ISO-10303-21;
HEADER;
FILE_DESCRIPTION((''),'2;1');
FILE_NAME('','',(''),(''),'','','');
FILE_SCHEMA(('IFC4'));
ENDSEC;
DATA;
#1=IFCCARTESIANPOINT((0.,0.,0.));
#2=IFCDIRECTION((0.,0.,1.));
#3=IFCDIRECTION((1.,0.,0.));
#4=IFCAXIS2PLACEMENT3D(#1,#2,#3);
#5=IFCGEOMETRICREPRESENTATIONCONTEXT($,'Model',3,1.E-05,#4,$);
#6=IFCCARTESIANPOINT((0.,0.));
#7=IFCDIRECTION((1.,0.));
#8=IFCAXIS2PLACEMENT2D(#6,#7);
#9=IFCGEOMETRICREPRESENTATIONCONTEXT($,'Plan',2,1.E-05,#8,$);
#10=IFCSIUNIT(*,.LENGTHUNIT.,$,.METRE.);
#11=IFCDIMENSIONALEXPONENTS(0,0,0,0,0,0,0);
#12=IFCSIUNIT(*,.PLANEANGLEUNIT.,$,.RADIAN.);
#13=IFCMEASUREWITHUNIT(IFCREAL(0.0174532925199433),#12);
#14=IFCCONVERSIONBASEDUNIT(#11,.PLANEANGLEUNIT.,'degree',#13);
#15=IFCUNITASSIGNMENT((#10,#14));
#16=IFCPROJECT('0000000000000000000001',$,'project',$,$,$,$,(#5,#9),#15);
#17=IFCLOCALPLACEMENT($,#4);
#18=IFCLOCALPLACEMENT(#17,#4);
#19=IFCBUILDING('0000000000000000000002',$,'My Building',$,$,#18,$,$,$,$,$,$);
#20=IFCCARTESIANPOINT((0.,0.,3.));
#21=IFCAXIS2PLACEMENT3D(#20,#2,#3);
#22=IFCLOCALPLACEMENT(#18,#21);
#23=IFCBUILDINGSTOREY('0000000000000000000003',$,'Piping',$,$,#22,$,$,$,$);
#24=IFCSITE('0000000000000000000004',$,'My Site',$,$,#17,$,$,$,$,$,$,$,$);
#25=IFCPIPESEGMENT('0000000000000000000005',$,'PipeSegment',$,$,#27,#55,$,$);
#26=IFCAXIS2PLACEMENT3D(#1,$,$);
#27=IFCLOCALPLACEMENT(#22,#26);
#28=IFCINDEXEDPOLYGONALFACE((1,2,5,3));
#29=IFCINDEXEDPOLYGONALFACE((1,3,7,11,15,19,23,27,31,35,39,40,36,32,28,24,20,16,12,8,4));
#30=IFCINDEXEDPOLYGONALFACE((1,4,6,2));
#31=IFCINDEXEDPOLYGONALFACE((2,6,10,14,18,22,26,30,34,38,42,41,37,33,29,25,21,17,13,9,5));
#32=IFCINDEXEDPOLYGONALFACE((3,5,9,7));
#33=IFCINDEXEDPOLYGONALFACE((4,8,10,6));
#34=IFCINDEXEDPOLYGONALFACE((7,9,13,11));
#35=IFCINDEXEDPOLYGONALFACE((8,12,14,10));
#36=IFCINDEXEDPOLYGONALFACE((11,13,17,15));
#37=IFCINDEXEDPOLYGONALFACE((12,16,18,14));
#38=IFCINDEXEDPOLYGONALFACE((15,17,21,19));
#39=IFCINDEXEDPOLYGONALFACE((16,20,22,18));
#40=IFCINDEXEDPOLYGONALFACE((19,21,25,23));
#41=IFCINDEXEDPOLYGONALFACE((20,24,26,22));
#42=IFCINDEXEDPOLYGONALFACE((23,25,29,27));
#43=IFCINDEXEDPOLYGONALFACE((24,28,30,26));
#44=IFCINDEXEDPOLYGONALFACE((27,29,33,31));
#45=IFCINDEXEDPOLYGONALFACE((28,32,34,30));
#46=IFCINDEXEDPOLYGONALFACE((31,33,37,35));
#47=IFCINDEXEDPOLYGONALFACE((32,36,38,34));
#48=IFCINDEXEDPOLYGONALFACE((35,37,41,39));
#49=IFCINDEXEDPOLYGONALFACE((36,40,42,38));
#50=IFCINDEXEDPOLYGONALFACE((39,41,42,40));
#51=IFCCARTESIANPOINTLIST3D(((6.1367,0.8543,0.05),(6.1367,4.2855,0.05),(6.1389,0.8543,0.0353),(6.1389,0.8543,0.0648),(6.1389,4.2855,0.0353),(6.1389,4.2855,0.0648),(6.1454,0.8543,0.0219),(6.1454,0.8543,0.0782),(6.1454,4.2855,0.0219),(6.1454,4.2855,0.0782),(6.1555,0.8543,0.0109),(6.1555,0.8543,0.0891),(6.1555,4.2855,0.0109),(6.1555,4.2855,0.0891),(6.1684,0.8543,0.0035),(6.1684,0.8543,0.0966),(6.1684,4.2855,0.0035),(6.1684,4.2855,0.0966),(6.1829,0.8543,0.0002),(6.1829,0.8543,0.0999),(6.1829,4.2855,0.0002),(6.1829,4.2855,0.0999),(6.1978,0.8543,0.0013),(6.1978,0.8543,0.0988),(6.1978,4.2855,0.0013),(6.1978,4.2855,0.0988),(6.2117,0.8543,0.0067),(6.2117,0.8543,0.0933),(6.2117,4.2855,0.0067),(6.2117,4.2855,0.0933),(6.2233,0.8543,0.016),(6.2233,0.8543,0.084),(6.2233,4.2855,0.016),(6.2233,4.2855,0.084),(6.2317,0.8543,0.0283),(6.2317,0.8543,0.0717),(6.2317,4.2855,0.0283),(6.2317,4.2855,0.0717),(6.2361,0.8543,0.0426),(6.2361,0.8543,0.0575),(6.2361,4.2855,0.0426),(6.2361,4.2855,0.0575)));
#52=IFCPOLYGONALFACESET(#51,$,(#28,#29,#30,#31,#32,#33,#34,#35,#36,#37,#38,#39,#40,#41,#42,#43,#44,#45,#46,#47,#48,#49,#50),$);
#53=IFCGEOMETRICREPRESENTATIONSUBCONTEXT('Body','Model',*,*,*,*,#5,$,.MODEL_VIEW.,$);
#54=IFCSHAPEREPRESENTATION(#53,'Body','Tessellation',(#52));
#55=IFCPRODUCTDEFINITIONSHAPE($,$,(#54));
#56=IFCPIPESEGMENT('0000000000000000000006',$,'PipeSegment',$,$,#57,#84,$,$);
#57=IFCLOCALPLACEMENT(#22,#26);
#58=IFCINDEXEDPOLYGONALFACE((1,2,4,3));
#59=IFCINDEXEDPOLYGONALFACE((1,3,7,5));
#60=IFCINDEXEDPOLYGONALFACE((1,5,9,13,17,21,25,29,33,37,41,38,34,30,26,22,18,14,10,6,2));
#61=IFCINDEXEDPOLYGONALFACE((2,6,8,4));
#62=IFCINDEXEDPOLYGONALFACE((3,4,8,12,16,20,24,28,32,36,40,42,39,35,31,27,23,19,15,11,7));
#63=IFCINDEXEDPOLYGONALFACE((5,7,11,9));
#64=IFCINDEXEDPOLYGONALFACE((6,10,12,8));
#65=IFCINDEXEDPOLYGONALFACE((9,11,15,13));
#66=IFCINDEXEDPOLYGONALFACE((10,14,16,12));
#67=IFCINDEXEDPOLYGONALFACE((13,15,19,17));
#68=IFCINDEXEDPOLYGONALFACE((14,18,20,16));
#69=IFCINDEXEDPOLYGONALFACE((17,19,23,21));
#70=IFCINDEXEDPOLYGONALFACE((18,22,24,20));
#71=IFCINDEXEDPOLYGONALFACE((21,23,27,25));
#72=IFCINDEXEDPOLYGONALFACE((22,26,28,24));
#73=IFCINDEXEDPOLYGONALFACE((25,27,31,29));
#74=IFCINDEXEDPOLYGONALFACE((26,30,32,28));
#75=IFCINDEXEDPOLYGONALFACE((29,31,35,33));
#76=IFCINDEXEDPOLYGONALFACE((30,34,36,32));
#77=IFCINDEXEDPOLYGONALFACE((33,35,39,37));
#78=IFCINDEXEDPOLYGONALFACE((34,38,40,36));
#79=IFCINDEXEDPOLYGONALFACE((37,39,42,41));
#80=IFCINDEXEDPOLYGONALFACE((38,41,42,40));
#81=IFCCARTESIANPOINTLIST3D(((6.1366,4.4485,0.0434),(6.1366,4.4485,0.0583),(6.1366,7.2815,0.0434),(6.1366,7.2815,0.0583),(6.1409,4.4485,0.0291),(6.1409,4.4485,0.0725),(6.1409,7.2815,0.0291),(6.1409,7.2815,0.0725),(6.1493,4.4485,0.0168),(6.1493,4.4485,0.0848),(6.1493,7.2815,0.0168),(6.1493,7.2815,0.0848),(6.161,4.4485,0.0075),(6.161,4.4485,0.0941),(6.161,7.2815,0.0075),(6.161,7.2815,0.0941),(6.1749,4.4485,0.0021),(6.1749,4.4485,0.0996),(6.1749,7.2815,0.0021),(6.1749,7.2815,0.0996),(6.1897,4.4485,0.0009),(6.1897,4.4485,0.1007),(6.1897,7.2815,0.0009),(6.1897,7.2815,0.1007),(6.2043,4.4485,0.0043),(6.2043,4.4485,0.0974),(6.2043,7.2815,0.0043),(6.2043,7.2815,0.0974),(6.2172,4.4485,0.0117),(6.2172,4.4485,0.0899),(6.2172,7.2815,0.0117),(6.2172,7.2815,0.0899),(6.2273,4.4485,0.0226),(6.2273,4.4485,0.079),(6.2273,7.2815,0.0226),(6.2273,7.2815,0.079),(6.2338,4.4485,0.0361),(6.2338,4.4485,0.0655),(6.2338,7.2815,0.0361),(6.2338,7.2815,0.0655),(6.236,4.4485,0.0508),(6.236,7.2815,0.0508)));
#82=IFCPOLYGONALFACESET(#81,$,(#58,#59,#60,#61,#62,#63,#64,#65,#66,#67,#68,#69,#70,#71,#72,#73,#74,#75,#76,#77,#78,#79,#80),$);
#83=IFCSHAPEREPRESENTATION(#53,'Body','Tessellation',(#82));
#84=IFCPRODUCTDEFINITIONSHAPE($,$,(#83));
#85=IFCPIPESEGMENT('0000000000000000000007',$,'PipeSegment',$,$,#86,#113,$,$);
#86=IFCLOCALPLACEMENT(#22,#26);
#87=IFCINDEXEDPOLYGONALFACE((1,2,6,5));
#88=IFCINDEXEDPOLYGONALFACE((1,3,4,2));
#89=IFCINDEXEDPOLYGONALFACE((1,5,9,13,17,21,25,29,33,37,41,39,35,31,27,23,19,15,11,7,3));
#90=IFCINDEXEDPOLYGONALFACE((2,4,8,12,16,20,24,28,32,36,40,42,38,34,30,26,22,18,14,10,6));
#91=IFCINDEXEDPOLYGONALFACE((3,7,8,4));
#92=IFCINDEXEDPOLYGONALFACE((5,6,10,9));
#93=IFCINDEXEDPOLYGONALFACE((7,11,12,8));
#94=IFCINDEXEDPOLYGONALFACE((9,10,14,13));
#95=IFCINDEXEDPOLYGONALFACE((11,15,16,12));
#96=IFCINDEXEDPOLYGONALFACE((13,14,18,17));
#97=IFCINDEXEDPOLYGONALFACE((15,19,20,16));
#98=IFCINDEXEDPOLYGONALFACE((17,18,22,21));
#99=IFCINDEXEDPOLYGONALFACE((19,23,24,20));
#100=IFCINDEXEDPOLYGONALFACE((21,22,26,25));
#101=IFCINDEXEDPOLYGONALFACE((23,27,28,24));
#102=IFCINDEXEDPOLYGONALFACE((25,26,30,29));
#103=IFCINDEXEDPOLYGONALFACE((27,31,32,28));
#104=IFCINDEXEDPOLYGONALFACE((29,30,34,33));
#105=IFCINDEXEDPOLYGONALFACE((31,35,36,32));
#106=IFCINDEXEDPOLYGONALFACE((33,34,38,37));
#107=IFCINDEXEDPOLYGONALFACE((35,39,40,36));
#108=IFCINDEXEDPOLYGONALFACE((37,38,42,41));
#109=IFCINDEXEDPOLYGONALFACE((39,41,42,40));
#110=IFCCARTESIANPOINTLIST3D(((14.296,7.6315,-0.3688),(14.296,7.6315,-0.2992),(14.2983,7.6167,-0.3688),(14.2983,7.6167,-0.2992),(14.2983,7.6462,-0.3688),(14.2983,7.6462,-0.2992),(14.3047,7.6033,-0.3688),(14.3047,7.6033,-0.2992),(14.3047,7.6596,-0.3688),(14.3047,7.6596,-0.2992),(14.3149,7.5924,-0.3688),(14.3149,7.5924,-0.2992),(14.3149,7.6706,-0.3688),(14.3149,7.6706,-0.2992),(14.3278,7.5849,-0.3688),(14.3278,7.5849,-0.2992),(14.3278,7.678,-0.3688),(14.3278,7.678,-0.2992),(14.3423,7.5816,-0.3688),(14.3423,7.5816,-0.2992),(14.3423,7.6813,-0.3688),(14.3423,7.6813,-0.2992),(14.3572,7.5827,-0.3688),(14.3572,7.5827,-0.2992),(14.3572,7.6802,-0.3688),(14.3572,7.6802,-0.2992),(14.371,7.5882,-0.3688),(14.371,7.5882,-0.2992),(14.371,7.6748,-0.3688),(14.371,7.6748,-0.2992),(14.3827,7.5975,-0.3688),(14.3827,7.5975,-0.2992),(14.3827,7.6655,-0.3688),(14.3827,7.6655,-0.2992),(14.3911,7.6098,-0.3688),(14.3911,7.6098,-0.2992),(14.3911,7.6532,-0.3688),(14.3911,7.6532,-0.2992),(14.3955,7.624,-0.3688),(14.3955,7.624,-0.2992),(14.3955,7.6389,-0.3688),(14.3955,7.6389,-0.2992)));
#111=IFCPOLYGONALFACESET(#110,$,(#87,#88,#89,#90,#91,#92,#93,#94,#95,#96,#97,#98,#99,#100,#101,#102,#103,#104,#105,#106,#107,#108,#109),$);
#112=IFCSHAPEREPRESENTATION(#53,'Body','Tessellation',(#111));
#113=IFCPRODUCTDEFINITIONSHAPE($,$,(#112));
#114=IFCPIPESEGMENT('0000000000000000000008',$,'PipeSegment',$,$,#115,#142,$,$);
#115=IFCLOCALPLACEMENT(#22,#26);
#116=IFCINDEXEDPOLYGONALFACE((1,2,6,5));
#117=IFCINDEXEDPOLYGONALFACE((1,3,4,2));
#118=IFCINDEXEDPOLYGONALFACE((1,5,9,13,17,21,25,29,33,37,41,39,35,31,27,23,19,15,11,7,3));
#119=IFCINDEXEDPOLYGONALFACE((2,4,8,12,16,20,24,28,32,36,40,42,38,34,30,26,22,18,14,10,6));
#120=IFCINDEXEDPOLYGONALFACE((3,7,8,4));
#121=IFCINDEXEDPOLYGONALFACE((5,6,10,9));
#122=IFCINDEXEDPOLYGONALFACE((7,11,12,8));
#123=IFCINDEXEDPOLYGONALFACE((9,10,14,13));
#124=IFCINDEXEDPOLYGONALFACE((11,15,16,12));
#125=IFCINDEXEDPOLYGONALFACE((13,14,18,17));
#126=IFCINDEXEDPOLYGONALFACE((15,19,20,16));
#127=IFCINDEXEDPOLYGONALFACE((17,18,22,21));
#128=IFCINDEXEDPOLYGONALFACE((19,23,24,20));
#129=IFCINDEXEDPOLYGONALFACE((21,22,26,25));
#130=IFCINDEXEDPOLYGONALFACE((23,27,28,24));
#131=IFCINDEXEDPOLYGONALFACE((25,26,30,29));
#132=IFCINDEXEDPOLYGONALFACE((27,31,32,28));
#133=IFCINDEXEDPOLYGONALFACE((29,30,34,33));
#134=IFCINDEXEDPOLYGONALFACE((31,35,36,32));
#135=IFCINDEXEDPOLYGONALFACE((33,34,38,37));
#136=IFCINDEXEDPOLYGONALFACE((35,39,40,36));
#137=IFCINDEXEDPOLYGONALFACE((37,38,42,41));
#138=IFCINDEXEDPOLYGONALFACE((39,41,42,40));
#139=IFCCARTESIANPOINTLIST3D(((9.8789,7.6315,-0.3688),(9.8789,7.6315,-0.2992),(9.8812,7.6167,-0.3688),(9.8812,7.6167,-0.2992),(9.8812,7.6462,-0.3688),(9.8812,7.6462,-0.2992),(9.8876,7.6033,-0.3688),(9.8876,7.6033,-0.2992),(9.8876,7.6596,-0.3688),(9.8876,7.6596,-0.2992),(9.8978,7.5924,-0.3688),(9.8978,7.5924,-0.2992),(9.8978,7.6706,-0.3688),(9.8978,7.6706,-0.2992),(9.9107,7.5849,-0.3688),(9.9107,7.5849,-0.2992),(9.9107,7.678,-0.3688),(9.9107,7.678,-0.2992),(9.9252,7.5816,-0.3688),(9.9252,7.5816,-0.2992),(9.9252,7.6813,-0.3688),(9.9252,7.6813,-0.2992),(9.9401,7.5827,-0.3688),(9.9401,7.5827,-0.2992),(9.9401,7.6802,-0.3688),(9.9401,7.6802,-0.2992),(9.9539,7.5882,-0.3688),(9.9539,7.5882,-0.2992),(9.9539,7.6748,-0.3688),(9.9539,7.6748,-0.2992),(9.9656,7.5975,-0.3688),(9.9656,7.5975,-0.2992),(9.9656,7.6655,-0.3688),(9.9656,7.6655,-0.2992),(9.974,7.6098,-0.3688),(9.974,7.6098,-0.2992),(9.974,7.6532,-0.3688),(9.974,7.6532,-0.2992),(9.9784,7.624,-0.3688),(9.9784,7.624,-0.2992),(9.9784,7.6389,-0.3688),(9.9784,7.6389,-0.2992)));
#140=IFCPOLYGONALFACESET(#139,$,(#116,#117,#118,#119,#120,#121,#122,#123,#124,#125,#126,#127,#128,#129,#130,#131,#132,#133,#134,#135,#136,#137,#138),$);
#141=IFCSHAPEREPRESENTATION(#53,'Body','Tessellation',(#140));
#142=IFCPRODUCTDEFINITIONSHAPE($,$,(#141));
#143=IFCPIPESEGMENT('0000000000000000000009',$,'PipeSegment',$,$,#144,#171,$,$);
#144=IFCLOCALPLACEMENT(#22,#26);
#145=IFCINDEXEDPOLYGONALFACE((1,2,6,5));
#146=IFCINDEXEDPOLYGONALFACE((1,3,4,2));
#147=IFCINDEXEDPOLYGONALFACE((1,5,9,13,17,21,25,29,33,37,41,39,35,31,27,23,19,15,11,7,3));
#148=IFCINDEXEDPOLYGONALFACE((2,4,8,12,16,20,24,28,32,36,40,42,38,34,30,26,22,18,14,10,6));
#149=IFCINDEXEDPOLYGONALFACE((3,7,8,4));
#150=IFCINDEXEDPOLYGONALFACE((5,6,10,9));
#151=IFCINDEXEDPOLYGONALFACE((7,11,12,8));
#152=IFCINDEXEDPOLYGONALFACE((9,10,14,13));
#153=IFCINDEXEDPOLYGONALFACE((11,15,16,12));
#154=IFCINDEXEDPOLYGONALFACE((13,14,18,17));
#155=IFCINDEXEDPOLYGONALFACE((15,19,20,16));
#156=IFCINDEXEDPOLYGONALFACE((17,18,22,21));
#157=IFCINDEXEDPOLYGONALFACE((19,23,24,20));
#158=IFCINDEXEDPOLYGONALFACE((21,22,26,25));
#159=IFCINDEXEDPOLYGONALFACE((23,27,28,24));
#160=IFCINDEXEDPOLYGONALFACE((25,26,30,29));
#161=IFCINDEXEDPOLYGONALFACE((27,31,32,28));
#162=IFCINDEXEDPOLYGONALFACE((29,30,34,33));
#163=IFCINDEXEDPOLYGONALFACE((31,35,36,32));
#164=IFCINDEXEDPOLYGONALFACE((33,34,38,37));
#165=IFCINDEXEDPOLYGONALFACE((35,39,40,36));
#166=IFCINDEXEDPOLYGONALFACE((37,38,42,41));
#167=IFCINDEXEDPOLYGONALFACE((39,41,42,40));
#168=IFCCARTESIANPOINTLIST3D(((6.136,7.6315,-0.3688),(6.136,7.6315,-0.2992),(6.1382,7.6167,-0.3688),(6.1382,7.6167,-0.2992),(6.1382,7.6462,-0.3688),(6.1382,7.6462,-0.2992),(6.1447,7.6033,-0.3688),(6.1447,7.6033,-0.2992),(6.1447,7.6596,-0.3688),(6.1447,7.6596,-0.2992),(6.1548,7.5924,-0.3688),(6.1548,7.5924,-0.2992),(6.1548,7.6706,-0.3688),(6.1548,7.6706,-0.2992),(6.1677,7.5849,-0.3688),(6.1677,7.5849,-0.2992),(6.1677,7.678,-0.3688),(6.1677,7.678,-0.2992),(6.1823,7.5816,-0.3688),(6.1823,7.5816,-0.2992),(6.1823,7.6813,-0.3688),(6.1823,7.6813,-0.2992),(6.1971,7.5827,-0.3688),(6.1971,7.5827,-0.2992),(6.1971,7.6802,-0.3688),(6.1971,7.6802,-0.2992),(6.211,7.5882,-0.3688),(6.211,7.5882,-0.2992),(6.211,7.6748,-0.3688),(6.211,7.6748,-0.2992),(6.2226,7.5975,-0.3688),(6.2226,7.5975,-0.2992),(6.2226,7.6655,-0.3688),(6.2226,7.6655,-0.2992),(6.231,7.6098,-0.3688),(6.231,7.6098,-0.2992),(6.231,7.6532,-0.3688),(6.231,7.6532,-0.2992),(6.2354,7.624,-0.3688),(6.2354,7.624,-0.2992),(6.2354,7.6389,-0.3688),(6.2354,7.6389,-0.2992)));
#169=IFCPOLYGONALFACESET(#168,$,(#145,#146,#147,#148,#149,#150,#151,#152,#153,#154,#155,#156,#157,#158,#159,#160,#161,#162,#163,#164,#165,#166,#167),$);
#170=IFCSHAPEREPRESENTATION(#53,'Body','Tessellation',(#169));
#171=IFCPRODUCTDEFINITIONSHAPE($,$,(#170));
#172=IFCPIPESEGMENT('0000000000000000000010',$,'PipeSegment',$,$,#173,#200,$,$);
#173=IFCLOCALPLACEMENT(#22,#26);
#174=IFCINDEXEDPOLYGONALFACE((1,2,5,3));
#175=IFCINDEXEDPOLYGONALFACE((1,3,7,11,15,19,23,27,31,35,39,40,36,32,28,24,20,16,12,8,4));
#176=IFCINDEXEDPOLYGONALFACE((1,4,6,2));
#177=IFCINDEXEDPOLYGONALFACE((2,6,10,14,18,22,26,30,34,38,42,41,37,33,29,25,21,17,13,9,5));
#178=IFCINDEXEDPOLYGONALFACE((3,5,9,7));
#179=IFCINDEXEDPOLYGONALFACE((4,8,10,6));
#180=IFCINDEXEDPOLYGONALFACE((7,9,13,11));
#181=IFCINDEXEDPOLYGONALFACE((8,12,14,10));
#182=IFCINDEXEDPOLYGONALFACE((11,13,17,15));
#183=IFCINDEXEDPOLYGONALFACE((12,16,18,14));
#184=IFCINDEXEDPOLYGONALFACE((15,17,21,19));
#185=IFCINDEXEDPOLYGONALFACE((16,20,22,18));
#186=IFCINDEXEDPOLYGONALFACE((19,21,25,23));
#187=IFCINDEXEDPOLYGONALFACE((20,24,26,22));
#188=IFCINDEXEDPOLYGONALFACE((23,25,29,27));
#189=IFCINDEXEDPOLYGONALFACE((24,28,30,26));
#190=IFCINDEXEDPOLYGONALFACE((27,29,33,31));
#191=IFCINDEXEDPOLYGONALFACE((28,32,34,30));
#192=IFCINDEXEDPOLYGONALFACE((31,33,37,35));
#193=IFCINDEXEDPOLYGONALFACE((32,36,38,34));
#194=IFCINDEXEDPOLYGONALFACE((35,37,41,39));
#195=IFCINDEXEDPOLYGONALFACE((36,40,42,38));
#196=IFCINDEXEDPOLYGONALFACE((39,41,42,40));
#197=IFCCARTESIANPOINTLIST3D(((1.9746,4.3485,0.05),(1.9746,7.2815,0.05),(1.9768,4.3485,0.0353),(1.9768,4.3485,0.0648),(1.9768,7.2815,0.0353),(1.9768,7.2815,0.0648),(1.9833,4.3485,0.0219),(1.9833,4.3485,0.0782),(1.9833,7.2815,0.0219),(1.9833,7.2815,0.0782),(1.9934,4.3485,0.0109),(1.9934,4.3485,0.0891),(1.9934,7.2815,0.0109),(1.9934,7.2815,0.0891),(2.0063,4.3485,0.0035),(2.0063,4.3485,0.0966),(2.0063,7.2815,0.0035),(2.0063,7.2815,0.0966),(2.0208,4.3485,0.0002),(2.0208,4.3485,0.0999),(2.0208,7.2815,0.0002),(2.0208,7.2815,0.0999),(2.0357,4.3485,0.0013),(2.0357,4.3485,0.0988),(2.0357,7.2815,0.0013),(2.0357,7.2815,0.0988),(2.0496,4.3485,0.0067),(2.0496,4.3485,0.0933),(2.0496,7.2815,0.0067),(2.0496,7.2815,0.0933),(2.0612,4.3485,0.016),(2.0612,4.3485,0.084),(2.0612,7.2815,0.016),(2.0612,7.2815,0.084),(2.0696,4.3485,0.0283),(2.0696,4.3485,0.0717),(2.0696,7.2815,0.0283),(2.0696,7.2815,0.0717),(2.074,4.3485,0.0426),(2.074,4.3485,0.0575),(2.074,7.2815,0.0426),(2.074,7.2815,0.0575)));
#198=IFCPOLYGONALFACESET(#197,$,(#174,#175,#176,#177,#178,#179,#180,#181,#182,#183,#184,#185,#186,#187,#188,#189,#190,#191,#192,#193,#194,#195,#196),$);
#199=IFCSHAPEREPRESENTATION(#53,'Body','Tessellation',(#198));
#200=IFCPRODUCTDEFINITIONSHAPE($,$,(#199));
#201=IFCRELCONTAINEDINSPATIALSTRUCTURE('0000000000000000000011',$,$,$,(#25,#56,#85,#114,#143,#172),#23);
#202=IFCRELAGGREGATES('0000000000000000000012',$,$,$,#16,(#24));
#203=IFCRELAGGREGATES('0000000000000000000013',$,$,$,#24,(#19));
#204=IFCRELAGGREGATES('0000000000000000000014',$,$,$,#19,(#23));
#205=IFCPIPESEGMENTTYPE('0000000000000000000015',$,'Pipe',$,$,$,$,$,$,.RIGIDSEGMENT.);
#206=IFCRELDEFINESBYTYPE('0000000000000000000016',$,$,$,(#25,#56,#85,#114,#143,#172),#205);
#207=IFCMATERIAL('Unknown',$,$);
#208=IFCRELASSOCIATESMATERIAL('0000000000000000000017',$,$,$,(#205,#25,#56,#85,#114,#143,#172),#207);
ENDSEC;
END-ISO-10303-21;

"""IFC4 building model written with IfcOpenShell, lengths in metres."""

from ifc_helpers import new_model, entity, si_unit, converted_unit, frame, origin_with_axes, origin_2d_with_axis, place, context, subcontext, project, spatial, circle, extrude, material, material_profile, profile_set, profile_usage, type_object, element, save


model = new_model("IFC4")

# Units and contexts
model_context = context("Model", 3, precision=1e-05, world=origin_with_axes())
plan_context = context("Plan", 2, precision=1e-05, world=origin_2d_with_axis())
body_context = subcontext(model_context, "Body", "Model", "MODEL_VIEW")
ifc_project = project(units=[si_unit("LENGTHUNIT", "METRE"), converted_unit("PLANEANGLEUNIT", "degree", entity("IfcReal", 0.0174532925199433), si_unit("PLANEANGLEUNIT", "RADIAN"), dimensions=[0, 0, 0, 0, 0, 0, 0])], contexts=[model_context, plan_context])

# Site, building, storey
site_placement = place(None, origin_with_axes())
site = spatial("IfcSite", under=ifc_project, at=site_placement, Name="My Site")
building_placement = place(site_placement, origin_with_axes())
building = spatial("IfcBuilding", under=site, at=building_placement, Name="My Building")
storey_placement = place(building_placement, frame((0.0, 0.0, 3.0), z_axis=(0.0, 0.0, 1.0), x_axis=(1.0, 0.0, 0.0)))
storey = spatial("IfcBuildingStorey", under=building, at=storey_placement, Name="Piping")

# Pipe segments
ifc_material = material(Name="Unknown")
ifc_material_profile_1 = material_profile(ifc_material, circle(Radius=0.05))
ifc_profile_set_1 = profile_set([ifc_material_profile_1])
pipe_segment_type = type_object("IfcPipeSegmentType", Name="Pipe", PredefinedType="RIGIDSEGMENT", material=ifc_profile_set_1)
ifc_profile_usage_1 = profile_usage(ifc_profile_set_1, cardinal=5)
pipe_segment_1_placement = place(storey_placement, frame((6.1867, 0.8543, 0.05), z_axis=(0.0, 1.0, 0.0), x_axis=(-1.0, 0.0, 0.0)))
element("IfcPipeSegment", 1, at=pipe_segment_1_placement, inside=storey, type_object=pipe_segment_type, material=ifc_profile_usage_1, Name="PipeSegment", context=body_context, shape_type="SweptSolid", body=[
    extrude(circle(Radius=0.05), origin_with_axes(), (0.0, 0.0, 1.0), 3.4313),
])
ifc_profile_usage_2 = profile_usage(ifc_profile_set_1, cardinal=5)
pipe_segment_2_placement = place(storey_placement, frame((6.186, 4.4485, 0.0508), z_axis=(0.0, 1.0, 0.0), x_axis=(1.0, 0.0, 0.0)))
element("IfcPipeSegment", 2, at=pipe_segment_2_placement, inside=storey, type_object=pipe_segment_type, material=ifc_profile_usage_2, Name="PipeSegment", context=body_context, shape_type="SweptSolid", body=[
    extrude(circle(Radius=0.05), origin_with_axes(), (0.0, 0.0, 1.0), 2.833),
])
ifc_profile_usage_3 = profile_usage(ifc_profile_set_1, cardinal=16)
pipe_segment_3_placement = place(storey_placement, frame((14.346, 7.6315, -0.2992), z_axis=(0.0, 0.0, -1.0), x_axis=(-1.0, 0.0, 0.0)))
element("IfcPipeSegment", 3, at=pipe_segment_3_placement, inside=storey, type_object=pipe_segment_type, material=ifc_profile_usage_3, Name="PipeSegment", context=body_context, shape_type="SweptSolid", body=[
    extrude(circle(Radius=0.05), origin_with_axes(), (0.0, 0.0, 1.0), 0.0696),
])
ifc_profile_usage_4 = profile_usage(ifc_profile_set_1, cardinal=16)
pipe_segment_4_placement = place(storey_placement, frame((9.9289, 7.6315, -0.2992), z_axis=(0.0, 0.0, -1.0), x_axis=(-1.0, 0.0, 0.0)))
element("IfcPipeSegment", 4, at=pipe_segment_4_placement, inside=storey, type_object=pipe_segment_type, material=ifc_profile_usage_4, Name="PipeSegment", context=body_context, shape_type="SweptSolid", body=[
    extrude(circle(Radius=0.05), origin_with_axes(), (0.0, 0.0, 1.0), 0.0696),
])
ifc_profile_usage_5 = profile_usage(ifc_profile_set_1, cardinal=16)
pipe_segment_5_placement = place(storey_placement, frame((6.186, 7.6315, -0.2992), z_axis=(0.0, 0.0, -1.0), x_axis=(-1.0, 0.0, 0.0)))
element("IfcPipeSegment", 5, at=pipe_segment_5_placement, inside=storey, type_object=pipe_segment_type, material=ifc_profile_usage_5, Name="PipeSegment", context=body_context, shape_type="SweptSolid", body=[
    extrude(circle(Radius=0.05), origin_with_axes(), (0.0, 0.0, 1.0), 0.0696),
])
ifc_profile_usage_6 = profile_usage(ifc_profile_set_1, cardinal=5)
pipe_segment_6_placement = place(storey_placement, frame((2.0246, 4.3485, 0.05), z_axis=(0.0, 1.0, 0.0), x_axis=(-1.0, 0.0, 0.0)))
element("IfcPipeSegment", 6, at=pipe_segment_6_placement, inside=storey, type_object=pipe_segment_type, material=ifc_profile_usage_6, Name="PipeSegment", context=body_context, shape_type="SweptSolid", body=[
    extrude(circle(Radius=0.05), origin_with_axes(), (0.0, 0.0, 1.0), 2.933),
])

save(model, "model.ifc")
